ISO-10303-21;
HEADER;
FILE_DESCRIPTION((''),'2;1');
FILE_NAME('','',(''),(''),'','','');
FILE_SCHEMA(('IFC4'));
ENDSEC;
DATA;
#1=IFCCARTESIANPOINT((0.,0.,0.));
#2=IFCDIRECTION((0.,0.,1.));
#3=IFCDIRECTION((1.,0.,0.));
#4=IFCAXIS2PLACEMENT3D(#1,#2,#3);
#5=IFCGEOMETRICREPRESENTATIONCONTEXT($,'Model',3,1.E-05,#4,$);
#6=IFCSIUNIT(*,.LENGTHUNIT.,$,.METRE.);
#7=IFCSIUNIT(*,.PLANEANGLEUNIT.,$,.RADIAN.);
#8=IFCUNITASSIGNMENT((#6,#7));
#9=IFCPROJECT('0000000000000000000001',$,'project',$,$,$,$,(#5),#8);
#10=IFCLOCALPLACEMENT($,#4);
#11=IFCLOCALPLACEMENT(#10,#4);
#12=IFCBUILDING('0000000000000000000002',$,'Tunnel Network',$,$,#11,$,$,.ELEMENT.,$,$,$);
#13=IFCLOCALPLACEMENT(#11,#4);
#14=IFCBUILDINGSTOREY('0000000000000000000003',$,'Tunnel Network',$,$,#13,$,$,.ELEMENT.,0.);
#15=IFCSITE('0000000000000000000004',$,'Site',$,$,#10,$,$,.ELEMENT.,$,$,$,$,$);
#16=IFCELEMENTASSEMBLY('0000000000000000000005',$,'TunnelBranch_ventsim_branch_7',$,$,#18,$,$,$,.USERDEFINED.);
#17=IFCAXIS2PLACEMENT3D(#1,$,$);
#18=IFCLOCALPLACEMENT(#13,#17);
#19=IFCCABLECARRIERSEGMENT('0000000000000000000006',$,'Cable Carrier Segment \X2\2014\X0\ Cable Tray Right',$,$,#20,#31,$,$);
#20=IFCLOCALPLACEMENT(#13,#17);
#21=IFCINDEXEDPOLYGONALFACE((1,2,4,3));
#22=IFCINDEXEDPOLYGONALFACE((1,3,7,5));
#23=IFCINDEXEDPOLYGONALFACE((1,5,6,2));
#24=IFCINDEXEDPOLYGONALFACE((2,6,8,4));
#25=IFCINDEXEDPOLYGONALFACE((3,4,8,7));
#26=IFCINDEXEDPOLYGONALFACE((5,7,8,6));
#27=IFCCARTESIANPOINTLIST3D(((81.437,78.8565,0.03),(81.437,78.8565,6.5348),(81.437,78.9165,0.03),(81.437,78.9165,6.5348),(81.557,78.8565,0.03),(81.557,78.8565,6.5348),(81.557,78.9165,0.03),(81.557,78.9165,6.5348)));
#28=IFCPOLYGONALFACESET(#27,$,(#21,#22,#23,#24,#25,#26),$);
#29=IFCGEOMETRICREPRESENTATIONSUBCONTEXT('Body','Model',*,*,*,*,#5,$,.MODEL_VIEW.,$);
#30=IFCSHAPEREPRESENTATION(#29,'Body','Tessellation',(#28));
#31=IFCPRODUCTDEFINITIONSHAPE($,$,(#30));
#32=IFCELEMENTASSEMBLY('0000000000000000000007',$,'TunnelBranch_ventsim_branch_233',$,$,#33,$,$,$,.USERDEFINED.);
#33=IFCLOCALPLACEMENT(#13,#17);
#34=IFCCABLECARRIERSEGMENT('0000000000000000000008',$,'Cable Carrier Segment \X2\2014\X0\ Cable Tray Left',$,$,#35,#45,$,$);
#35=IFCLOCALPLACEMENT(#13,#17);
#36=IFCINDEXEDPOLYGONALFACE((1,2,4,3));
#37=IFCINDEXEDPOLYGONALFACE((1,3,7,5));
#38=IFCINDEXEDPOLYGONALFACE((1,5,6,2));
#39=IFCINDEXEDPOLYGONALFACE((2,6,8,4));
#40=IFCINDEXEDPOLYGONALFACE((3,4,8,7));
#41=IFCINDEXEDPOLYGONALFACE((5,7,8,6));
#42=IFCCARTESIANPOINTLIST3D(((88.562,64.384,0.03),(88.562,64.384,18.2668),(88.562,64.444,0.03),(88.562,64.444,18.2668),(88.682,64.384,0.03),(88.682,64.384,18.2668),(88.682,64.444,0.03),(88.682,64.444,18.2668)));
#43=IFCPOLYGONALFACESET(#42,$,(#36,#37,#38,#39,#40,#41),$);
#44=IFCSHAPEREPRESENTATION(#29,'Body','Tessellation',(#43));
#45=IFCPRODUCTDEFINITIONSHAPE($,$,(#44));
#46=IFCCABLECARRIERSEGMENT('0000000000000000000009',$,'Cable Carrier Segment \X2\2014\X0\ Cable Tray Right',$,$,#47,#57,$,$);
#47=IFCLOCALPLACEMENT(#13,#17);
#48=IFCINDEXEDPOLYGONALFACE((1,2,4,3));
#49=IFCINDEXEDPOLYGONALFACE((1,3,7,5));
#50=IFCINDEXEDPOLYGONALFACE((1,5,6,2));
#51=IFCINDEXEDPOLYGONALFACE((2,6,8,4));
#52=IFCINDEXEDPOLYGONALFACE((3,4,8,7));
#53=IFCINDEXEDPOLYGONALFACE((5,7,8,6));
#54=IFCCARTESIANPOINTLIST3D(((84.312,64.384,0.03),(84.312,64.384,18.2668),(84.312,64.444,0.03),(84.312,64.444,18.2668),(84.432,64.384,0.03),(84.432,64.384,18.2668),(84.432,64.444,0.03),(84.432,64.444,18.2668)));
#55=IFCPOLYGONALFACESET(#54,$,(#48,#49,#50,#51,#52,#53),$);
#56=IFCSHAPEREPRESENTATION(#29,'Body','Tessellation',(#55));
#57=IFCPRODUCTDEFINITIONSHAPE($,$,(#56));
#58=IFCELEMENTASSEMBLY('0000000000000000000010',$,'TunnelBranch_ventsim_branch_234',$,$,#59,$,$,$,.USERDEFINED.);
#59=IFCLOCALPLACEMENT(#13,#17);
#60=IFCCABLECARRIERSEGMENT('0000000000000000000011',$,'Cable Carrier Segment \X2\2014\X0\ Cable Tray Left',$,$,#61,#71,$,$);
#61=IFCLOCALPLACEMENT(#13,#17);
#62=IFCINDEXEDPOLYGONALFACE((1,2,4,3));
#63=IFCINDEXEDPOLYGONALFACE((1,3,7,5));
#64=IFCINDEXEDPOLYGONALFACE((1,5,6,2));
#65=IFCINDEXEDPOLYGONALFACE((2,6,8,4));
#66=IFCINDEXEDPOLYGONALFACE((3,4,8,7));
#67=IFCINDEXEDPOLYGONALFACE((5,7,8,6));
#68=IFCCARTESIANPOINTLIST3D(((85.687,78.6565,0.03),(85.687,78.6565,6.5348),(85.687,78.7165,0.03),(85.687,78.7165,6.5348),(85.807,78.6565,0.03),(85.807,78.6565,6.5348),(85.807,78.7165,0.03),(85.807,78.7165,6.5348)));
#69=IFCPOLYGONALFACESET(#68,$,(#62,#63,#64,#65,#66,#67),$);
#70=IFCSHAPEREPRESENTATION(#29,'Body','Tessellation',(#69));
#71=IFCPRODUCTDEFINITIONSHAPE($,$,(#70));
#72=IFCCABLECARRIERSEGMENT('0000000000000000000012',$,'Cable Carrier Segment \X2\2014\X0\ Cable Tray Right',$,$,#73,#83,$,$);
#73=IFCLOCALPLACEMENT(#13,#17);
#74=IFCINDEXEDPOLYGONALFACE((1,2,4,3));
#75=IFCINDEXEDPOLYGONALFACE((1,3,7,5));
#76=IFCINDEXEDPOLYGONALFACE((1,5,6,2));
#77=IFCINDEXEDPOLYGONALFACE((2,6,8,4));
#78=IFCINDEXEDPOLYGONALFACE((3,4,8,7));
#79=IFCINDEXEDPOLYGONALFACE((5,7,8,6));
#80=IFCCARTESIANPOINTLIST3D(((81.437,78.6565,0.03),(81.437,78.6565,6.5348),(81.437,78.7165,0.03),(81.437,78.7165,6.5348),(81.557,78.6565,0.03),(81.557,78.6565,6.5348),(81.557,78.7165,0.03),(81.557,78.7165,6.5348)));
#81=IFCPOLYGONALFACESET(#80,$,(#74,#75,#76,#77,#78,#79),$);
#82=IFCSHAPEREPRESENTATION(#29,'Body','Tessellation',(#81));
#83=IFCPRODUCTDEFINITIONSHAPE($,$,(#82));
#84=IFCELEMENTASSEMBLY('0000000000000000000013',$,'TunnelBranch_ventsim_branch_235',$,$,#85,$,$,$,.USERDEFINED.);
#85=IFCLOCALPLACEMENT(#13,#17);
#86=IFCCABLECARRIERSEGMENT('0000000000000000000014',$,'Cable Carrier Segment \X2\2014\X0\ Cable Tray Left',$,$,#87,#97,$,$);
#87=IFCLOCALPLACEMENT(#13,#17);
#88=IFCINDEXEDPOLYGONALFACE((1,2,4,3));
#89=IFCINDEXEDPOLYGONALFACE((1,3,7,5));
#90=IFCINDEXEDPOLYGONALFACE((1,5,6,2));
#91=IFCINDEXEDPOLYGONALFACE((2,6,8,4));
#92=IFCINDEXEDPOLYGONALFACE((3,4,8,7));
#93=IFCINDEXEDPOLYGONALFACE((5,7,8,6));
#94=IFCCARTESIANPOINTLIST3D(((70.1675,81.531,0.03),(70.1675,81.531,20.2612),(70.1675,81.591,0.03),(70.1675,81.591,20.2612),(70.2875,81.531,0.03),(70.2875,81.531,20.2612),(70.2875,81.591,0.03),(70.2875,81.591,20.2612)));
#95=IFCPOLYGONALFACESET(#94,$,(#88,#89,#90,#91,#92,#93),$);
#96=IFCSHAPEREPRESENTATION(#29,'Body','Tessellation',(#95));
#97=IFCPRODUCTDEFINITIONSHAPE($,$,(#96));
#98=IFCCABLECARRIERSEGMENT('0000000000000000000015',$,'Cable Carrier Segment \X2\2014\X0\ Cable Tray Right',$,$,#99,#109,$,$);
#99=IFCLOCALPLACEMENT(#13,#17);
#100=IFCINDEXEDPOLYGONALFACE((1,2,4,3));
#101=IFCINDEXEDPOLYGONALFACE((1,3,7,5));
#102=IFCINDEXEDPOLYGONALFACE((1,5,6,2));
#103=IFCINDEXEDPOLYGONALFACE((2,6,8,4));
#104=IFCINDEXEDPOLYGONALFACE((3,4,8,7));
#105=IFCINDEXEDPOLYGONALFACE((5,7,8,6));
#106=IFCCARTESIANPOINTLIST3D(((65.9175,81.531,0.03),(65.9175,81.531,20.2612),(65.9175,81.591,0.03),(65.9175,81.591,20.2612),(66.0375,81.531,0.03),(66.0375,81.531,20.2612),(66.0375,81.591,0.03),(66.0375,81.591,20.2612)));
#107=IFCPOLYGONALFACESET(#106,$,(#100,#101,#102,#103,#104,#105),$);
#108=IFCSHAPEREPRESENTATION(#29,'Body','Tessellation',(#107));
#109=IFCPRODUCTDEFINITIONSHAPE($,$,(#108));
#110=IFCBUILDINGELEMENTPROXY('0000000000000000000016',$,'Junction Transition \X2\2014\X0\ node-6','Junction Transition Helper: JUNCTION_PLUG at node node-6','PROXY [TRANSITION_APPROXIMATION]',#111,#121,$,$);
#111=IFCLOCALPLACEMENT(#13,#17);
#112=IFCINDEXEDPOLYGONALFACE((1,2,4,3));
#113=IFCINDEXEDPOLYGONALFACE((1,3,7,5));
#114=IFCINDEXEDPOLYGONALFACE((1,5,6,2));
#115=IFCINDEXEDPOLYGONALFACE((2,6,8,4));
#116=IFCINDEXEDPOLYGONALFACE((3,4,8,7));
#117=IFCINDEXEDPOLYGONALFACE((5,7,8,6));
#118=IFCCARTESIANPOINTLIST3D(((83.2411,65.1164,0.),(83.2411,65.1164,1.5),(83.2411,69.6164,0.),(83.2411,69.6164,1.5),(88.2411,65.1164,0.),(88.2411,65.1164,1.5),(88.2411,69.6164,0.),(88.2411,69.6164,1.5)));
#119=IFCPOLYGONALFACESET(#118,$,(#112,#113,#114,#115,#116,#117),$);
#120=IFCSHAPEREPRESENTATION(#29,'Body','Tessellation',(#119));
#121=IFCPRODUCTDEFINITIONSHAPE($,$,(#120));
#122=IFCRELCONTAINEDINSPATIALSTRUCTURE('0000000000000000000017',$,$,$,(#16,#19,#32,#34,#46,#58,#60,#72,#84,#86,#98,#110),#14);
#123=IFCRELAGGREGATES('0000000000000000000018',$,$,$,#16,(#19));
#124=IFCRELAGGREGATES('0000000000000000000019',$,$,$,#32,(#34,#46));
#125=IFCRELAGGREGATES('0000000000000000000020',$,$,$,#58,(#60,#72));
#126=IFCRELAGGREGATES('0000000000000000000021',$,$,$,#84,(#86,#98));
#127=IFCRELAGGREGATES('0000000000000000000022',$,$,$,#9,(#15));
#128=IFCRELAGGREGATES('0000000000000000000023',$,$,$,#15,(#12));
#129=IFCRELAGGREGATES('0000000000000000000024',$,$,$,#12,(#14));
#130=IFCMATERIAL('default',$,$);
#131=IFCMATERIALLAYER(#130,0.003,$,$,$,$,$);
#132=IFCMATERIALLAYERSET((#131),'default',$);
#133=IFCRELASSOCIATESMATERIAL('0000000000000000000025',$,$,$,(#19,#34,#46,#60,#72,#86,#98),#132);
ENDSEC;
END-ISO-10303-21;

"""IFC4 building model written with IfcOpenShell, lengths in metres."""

from ifc_helpers import new_model, si_unit, frame, origin_with_axes, origin_2d_with_axis, place, context, subcontext, project, spatial, rectangle, extrude, material, layer, layer_set, layer_usage, element, aggregate, save


model = new_model("IFC4")

# Units and contexts
model_context = context("Model", 3, precision=1e-05, world=origin_with_axes())
body_context = subcontext(model_context, "Body", "Model", "MODEL_VIEW")
ifc_project = project(units=[si_unit("LENGTHUNIT", "METRE"), si_unit("PLANEANGLEUNIT", "RADIAN")], contexts=[model_context])

# Site, building, storey
site_placement = place(None, origin_with_axes())
site = spatial("IfcSite", under=ifc_project, at=site_placement, Name="Site", CompositionType="ELEMENT")
building_placement = place(site_placement, origin_with_axes())
building = spatial("IfcBuilding", under=site, at=building_placement, Name="Tunnel Network", CompositionType="ELEMENT")
storey_placement = place(building_placement, origin_with_axes())
storey = spatial("IfcBuildingStorey", under=building, at=storey_placement, Name="Tunnel Network", CompositionType="ELEMENT", Elevation=0.0)

# Element assemblies, cable carrier segments
ifc_material_1 = material(Name="default")
ifc_layer_1 = layer(ifc_material_1, 0.003)
ifc_layer_set_1 = layer_set([ifc_layer_1], Name="default")
assembly_1_placement = place(storey_placement, frame((83.622, 80.0115, 0.8131), z_axis=(0.0, 0.0, 1.0), x_axis=(-1.0, 0.0, 0.0)))
assembly_1 = element("IfcElementAssembly", 1, at=assembly_1_placement, inside=storey, Name="TunnelBranch_ventsim_branch_7", PredefinedType="USERDEFINED")
ifc_layer_usage_1 = layer_usage(ifc_layer_set_1, "AXIS2", "POSITIVE", 0.0)
cable_carrier_segment_1_placement = place(storey_placement, frame((81.497, 78.8865, 0.03), z_axis=(0.0, 0.0, 1.0), x_axis=(-1.0, 0.0, 0.0)))
cable_carrier_segment_1 = element("IfcCableCarrierSegment", 2, at=cable_carrier_segment_1_placement, inside=storey, material=ifc_layer_usage_1, Name="Cable Carrier Segment — Cable Tray Right", context=body_context, shape_type="SweptSolid", body=[
    extrude(rectangle(XDim=0.12, YDim=0.06, at=origin_2d_with_axis()), origin_with_axes(), (0.0, 0.0, 1.0), 6.5048),
])
aggregate(assembly_1, [cable_carrier_segment_1])
assembly_2_placement = place(storey_placement, frame((86.497, 65.314, 1.25), z_axis=(0.0, 1.0, 0.0), x_axis=(-1.0, 0.0, 0.0)))
assembly_2 = element("IfcElementAssembly", 3, at=assembly_2_placement, inside=storey, Name="TunnelBranch_ventsim_branch_233", PredefinedType="USERDEFINED")
ifc_layer_usage_2 = layer_usage(ifc_layer_set_1, "AXIS2", "POSITIVE", 0.0)
cable_carrier_segment_2_placement = place(storey_placement, frame((88.622, 64.414, 0.03), z_axis=(0.0, 0.0, 1.0), x_axis=(-1.0, 0.0, 0.0)))
cable_carrier_segment_2 = element("IfcCableCarrierSegment", 4, at=cable_carrier_segment_2_placement, inside=storey, material=ifc_layer_usage_2, Name="Cable Carrier Segment — Cable Tray Left", context=body_context, shape_type="SweptSolid", body=[
    extrude(rectangle(XDim=0.12, YDim=0.06, at=origin_2d_with_axis()), origin_with_axes(), (0.0, 0.0, 1.0), 18.2368),
])
ifc_layer_usage_3 = layer_usage(ifc_layer_set_1, "AXIS2", "POSITIVE", 0.0)
cable_carrier_segment_3_placement = place(storey_placement, frame((84.372, 64.414, 0.03), z_axis=(0.0, 0.0, 1.0), x_axis=(-1.0, 0.0, 0.0)))
cable_carrier_segment_3 = element("IfcCableCarrierSegment", 5, at=cable_carrier_segment_3_placement, inside=storey, material=ifc_layer_usage_3, Name="Cable Carrier Segment — Cable Tray Right", context=body_context, shape_type="SweptSolid", body=[
    extrude(rectangle(XDim=0.12, YDim=0.06, at=origin_2d_with_axis()), origin_with_axes(), (0.0, 0.0, 1.0), 18.2368),
])
aggregate(assembly_2, [cable_carrier_segment_2, cable_carrier_segment_3])
assembly_3_placement = place(storey_placement, frame((83.622, 79.5865, 1.25), z_axis=(0.0, 1.0, 0.0), x_axis=(-1.0, 0.0, 0.0)))
assembly_3 = element("IfcElementAssembly", 6, at=assembly_3_placement, inside=storey, Name="TunnelBranch_ventsim_branch_234", PredefinedType="USERDEFINED")
ifc_layer_usage_4 = layer_usage(ifc_layer_set_1, "AXIS2", "POSITIVE", 0.0)
cable_carrier_segment_4_placement = place(storey_placement, frame((85.747, 78.6865, 0.03), z_axis=(0.0, 0.0, 1.0), x_axis=(-1.0, 0.0, 0.0)))
cable_carrier_segment_4 = element("IfcCableCarrierSegment", 7, at=cable_carrier_segment_4_placement, inside=storey, material=ifc_layer_usage_4, Name="Cable Carrier Segment — Cable Tray Left", context=body_context, shape_type="SweptSolid", body=[
    extrude(rectangle(XDim=0.12, YDim=0.06, at=origin_2d_with_axis()), origin_with_axes(), (0.0, 0.0, 1.0), 6.5048),
])
ifc_layer_usage_5 = layer_usage(ifc_layer_set_1, "AXIS2", "POSITIVE", 0.0)
cable_carrier_segment_5_placement = place(storey_placement, frame((81.497, 78.6865, 0.03), z_axis=(0.0, 0.0, 1.0), x_axis=(-1.0, 0.0, 0.0)))
cable_carrier_segment_5 = element("IfcCableCarrierSegment", 8, at=cable_carrier_segment_5_placement, inside=storey, material=ifc_layer_usage_5, Name="Cable Carrier Segment — Cable Tray Right", context=body_context, shape_type="SweptSolid", body=[
    extrude(rectangle(XDim=0.12, YDim=0.06, at=origin_2d_with_axis()), origin_with_axes(), (0.0, 0.0, 1.0), 6.5048),
])
aggregate(assembly_3, [cable_carrier_segment_4, cable_carrier_segment_5])
assembly_4_placement = place(storey_placement, frame((68.1025, 82.461, 1.0), z_axis=(0.0, 1.0, 0.0), x_axis=(-1.0, 0.0, 0.0)))
assembly_4 = element("IfcElementAssembly", 9, at=assembly_4_placement, inside=storey, Name="TunnelBranch_ventsim_branch_235", PredefinedType="USERDEFINED")
ifc_layer_usage_6 = layer_usage(ifc_layer_set_1, "AXIS2", "POSITIVE", 0.0)
cable_carrier_segment_6_placement = place(storey_placement, frame((70.2275, 81.561, 0.03), z_axis=(0.0, 0.0, 1.0), x_axis=(-1.0, 0.0, 0.0)))
cable_carrier_segment_6 = element("IfcCableCarrierSegment", 10, at=cable_carrier_segment_6_placement, inside=storey, material=ifc_layer_usage_6, Name="Cable Carrier Segment — Cable Tray Left", context=body_context, shape_type="SweptSolid", body=[
    extrude(rectangle(XDim=0.12, YDim=0.06, at=origin_2d_with_axis()), origin_with_axes(), (0.0, 0.0, 1.0), 20.2312),
])
ifc_layer_usage_7 = layer_usage(ifc_layer_set_1, "AXIS2", "POSITIVE", 0.0)
cable_carrier_segment_7_placement = place(storey_placement, frame((65.9775, 81.561, 0.03), z_axis=(0.0, 0.0, 1.0), x_axis=(-1.0, 0.0, 0.0)))
cable_carrier_segment_7 = element("IfcCableCarrierSegment", 11, at=cable_carrier_segment_7_placement, inside=storey, material=ifc_layer_usage_7, Name="Cable Carrier Segment — Cable Tray Right", context=body_context, shape_type="SweptSolid", body=[
    extrude(rectangle(XDim=0.12, YDim=0.06, at=origin_2d_with_axis()), origin_with_axes(), (0.0, 0.0, 1.0), 20.2312),
])
aggregate(assembly_4, [cable_carrier_segment_6, cable_carrier_segment_7])

# Building element proxy
proxy_placement = place(storey_placement, frame((85.7411, 67.3664, 0.0), z_axis=(0.0, 0.0, 1.0), x_axis=(1.0, 0.0, 0.0)))
element("IfcBuildingElementProxy", 12, at=proxy_placement, inside=storey, Name="Junction Transition — node-6", Description="Junction Transition Helper: JUNCTION_PLUG at node node-6", ObjectType="PROXY [TRANSITION_APPROXIMATION]", context=body_context, shape_type="SweptSolid", body=[
    extrude(rectangle(XDim=5.0, YDim=4.5, at=origin_2d_with_axis()), origin_with_axes(), (0.0, 0.0, 1.0), 1.5),
])

save(model, "model.ifc")
